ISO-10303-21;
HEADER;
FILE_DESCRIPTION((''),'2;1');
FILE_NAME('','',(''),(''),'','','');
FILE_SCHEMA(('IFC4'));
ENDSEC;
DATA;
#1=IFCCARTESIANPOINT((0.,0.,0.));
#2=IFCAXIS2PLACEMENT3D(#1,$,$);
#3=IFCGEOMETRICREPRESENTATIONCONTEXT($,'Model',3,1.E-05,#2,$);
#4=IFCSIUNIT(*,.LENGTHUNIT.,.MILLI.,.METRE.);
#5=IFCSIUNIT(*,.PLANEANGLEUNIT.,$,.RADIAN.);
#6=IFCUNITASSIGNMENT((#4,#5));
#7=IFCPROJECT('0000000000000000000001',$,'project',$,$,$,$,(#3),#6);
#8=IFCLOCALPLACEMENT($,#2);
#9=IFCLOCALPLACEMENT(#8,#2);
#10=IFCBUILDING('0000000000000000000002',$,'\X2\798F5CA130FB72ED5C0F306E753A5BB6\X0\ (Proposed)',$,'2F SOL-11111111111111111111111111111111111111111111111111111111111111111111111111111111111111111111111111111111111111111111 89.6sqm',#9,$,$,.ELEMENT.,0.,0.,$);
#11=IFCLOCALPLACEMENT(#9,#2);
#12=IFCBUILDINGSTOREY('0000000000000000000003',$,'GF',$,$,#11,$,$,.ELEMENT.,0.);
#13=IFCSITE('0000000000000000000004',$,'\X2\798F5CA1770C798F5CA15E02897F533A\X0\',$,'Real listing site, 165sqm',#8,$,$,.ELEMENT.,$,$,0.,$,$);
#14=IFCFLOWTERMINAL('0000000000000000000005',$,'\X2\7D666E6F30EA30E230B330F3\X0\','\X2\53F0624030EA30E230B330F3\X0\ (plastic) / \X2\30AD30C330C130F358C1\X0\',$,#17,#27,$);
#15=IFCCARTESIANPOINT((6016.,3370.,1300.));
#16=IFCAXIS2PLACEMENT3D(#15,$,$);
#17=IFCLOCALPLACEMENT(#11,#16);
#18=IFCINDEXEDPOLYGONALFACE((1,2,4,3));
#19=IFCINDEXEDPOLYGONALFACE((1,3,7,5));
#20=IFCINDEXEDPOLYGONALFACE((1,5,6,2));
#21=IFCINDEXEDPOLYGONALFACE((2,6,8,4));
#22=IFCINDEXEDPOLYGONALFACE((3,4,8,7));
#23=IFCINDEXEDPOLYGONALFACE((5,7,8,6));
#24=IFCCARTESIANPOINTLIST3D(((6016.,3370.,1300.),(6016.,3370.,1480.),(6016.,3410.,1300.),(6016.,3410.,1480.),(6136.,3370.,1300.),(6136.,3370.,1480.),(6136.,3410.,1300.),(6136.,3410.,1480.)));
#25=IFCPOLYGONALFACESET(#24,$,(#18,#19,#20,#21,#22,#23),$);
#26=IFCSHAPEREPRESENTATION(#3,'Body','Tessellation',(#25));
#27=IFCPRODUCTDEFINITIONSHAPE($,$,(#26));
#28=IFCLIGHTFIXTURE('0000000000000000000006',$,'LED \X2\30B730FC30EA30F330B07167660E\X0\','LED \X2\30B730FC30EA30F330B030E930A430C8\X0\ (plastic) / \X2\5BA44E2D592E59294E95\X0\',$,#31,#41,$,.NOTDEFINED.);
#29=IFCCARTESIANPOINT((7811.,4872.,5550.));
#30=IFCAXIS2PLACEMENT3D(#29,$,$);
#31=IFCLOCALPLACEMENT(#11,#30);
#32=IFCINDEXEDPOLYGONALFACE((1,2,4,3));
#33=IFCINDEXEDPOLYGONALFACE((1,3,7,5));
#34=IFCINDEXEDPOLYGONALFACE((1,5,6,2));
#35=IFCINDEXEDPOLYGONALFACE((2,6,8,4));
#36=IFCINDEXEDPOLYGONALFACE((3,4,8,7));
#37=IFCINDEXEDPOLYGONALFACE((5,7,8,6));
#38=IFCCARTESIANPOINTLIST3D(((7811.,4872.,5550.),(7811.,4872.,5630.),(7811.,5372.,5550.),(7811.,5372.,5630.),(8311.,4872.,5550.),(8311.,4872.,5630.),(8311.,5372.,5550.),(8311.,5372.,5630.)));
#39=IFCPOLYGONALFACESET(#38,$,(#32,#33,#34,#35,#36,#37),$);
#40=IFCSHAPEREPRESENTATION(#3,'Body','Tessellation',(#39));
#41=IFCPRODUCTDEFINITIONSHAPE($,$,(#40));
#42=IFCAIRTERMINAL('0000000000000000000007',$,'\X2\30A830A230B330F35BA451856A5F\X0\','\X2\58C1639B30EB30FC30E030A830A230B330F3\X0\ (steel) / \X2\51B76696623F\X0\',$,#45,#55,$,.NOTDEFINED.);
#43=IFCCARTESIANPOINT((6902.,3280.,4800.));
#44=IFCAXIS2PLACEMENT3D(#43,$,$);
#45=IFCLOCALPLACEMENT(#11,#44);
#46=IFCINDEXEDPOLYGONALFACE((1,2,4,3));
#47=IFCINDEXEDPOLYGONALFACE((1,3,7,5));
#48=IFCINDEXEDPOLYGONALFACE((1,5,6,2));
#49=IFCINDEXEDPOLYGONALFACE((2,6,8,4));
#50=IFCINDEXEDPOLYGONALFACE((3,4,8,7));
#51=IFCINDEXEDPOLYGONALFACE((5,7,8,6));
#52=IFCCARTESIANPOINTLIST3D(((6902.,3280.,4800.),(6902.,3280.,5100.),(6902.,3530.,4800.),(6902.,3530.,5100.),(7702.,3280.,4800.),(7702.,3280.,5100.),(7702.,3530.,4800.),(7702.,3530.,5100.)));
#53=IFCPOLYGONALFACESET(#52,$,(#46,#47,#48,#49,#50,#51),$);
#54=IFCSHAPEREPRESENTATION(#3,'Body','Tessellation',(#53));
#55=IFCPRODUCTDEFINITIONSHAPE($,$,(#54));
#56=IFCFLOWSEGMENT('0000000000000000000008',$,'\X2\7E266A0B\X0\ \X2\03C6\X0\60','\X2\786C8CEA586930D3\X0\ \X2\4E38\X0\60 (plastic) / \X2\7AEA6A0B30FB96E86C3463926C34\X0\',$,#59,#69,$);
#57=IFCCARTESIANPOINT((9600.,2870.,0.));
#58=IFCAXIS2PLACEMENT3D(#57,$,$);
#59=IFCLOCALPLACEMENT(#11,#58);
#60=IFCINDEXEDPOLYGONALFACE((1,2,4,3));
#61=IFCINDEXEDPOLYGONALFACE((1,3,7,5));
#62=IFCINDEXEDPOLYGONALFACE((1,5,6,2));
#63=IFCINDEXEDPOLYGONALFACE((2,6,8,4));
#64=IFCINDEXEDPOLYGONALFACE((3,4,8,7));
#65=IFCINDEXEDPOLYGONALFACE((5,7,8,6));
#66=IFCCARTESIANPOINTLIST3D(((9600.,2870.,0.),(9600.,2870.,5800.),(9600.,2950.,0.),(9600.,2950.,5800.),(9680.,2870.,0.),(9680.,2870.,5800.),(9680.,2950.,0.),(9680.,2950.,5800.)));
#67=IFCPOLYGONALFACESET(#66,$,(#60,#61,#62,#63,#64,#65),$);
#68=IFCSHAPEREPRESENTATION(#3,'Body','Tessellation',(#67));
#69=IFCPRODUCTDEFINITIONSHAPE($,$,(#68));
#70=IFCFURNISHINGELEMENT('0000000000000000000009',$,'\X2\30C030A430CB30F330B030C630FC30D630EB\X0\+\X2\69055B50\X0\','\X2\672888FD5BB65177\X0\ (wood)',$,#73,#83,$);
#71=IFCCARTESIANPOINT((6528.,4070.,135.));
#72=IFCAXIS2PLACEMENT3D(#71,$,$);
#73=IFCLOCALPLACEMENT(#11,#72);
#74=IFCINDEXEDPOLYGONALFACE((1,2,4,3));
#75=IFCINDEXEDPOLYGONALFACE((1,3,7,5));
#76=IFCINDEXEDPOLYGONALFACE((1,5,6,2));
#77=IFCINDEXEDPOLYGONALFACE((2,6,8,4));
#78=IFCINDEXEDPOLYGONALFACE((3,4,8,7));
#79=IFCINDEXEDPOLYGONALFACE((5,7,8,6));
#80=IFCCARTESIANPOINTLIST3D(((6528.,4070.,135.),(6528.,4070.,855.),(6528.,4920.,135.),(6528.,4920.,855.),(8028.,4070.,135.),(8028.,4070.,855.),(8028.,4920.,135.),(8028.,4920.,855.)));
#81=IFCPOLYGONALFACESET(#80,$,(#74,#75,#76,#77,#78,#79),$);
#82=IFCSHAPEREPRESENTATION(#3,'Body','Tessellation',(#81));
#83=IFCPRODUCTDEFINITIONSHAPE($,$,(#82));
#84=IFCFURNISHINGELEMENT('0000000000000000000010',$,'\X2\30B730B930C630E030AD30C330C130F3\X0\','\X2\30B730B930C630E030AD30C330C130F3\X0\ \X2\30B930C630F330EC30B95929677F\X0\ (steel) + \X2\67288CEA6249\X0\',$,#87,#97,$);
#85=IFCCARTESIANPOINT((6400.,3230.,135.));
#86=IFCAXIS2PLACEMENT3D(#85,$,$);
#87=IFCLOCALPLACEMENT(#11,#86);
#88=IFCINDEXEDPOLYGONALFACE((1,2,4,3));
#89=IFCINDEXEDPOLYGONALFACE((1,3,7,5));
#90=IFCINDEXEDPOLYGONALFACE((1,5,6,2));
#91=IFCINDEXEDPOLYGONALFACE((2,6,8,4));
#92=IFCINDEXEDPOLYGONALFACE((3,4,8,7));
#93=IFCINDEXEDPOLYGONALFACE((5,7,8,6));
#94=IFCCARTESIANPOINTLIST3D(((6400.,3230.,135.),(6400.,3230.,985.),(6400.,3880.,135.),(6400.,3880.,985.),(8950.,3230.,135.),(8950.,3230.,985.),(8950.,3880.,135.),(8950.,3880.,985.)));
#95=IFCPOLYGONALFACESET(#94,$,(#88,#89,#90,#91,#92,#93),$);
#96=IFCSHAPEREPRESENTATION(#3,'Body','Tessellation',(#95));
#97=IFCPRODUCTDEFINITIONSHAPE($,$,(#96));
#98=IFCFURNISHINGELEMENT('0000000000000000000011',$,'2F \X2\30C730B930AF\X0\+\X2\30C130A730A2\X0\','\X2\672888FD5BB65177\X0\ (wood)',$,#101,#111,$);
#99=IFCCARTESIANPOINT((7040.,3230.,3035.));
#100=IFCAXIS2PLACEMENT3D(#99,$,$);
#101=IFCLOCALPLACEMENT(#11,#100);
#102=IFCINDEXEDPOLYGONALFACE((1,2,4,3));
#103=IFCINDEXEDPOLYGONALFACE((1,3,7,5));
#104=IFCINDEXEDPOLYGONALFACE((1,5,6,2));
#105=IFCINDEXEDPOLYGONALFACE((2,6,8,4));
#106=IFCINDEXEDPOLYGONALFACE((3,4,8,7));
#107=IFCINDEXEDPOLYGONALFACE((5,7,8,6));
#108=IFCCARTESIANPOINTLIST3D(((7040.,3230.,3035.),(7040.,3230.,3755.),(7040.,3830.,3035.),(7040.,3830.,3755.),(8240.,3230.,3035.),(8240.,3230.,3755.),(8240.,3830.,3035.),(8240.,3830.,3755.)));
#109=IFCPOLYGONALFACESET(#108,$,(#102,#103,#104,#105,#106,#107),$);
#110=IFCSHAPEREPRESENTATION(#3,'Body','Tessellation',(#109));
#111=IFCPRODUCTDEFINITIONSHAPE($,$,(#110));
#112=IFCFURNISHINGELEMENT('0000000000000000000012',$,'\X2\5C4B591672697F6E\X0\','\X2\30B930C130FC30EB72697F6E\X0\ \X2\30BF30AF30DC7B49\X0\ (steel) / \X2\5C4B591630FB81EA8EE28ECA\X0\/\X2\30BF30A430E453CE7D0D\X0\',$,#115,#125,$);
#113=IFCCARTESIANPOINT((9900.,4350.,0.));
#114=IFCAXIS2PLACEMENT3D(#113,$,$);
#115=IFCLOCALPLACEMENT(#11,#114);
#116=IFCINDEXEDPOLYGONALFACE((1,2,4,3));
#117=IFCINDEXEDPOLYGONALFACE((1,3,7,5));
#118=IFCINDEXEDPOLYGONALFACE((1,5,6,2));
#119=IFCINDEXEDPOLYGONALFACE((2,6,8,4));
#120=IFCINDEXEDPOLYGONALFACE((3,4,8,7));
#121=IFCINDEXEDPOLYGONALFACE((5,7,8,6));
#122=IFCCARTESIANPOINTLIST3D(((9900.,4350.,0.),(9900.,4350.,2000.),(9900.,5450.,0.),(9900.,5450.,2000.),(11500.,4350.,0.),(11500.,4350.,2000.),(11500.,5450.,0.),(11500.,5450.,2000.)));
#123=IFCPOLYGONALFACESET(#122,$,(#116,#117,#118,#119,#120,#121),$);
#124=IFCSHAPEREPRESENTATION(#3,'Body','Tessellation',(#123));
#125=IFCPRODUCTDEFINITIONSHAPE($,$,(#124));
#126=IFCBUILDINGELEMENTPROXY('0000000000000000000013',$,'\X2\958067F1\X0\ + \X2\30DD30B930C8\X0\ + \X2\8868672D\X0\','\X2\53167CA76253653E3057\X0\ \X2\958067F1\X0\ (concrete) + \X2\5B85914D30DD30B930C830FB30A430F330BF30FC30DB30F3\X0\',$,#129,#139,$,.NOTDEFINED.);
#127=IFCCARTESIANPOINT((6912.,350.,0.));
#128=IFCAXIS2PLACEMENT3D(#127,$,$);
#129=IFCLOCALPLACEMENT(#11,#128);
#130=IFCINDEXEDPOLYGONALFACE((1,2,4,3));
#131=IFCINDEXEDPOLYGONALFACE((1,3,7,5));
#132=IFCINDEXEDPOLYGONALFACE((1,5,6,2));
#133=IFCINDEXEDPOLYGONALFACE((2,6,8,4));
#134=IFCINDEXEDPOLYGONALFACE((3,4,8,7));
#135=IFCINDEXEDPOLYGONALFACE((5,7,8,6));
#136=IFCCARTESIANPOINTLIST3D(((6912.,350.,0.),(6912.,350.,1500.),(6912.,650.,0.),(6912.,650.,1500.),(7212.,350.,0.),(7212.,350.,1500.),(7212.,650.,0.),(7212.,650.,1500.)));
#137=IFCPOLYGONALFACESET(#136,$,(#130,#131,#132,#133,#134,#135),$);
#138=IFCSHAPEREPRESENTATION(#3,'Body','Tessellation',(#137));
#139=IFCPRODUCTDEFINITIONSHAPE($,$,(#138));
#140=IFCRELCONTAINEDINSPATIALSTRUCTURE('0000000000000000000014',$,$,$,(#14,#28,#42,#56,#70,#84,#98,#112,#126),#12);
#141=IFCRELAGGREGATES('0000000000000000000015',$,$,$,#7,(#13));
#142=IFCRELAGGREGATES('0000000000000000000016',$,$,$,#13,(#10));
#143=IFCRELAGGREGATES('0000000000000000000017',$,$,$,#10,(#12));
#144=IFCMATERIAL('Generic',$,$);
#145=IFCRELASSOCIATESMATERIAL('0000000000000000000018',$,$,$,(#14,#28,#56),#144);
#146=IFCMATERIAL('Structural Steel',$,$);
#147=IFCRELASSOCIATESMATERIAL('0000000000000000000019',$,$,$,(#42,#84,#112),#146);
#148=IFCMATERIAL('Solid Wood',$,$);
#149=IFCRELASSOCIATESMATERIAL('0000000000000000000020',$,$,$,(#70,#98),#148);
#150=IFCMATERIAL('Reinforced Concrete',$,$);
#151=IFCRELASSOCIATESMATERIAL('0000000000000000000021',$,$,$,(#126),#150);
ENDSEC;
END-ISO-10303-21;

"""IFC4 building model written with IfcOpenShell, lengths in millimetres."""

from ifc_helpers import new_model, si_unit, frame, frame_2d, origin, place, context, project, spatial, rectangle, extrude, material, element, save


model = new_model("IFC4")

# Units and contexts
model_context = context("Model", 3, precision=1e-05, world=origin())
ifc_project = project(units=[si_unit("LENGTHUNIT", "METRE", prefix="MILLI"), si_unit("PLANEANGLEUNIT", "RADIAN")], contexts=[model_context])

# Site, building, storey
site_placement = place(None, origin())
site = spatial("IfcSite", under=ifc_project, at=site_placement, Name="福岡県福岡市西区", ObjectType="Real listing site, 165sqm", CompositionType="ELEMENT", RefElevation=0.0)
building_placement = place(site_placement, origin())
building = spatial("IfcBuilding", under=site, at=building_placement, Name="福岡・狭小の町家 (Proposed)", ObjectType="2F SOL-11111111111111111111111111111111111111111111111111111111111111111111111111111111111111111111111111111111111111111111 89.6sqm", CompositionType="ELEMENT", ElevationOfRefHeight=0.0, ElevationOfTerrain=0.0)
storey_placement = place(building_placement, origin())
storey = spatial("IfcBuildingStorey", under=building, at=storey_placement, Name="GF", CompositionType="ELEMENT", Elevation=0.0)

# Shared definitions
ifc_material_1 = material(Name="Solid Wood")

# Shared definitions
ifc_material_2 = material(Name="Reinforced Concrete")

# Shared definitions
ifc_material_3 = material(Name="Structural Steel")

# Flow terminal
ifc_material_4 = material(Name="Generic")
flow_terminal_1_placement = place(storey_placement, frame((6016.0, 3370.0, 1300.0)))
element("IfcFlowTerminal", 1, at=flow_terminal_1_placement, inside=storey, material=ifc_material_4, Name="給湯リモコン", Description="台所リモコン (plastic) / キッチン壁", context=model_context, shape_type="SweptSolid", body=[
    extrude(rectangle(XDim=120.0, YDim=40.0, at=frame_2d((60.0, 20.0))), frame((6016.0, 3370.0, 1300.0)), (0.0, 0.0, 1.0), 180.0),
])

# Light fixture
light_fixture_placement = place(storey_placement, frame((7811.0, 4872.0, 5550.0)))
element("IfcLightFixture", 2, at=light_fixture_placement, inside=storey, material=ifc_material_4, Name="LED シーリング照明", Description="LED シーリングライト (plastic) / 室中央天井", PredefinedType="NOTDEFINED", context=model_context, shape_type="SweptSolid", body=[
    extrude(rectangle(XDim=500.0, YDim=500.0, at=frame_2d((250.0, 250.0))), frame((7811.0, 4872.0, 5550.0)), (0.0, 0.0, 1.0), 80.0),
])

# Air terminal
air_terminal_placement = place(storey_placement, frame((6902.0, 3280.0, 4800.0)))
element("IfcAirTerminal", 3, at=air_terminal_placement, inside=storey, material=ifc_material_3, Name="エアコン室内機", Description="壁掛ルームエアコン (steel) / 冷暖房", PredefinedType="NOTDEFINED", context=model_context, shape_type="SweptSolid", body=[
    extrude(rectangle(XDim=800.0, YDim=250.0, at=frame_2d((400.0, 125.0))), frame((6902.0, 3280.0, 4800.0)), (0.0, 0.0, 1.0), 300.0),
])

# Flow segment
flow_segment_placement = place(storey_placement, frame((9600.0, 2870.0, 0.0)))
element("IfcFlowSegment", 4, at=flow_segment_placement, inside=storey, material=ifc_material_4, Name="縦樋 φ60", Description="硬質塩ビ 丸60 (plastic) / 竪樋・雨水排水", context=model_context, shape_type="SweptSolid", body=[
    extrude(rectangle(XDim=80.0, YDim=80.0, at=frame_2d((40.0, 40.0))), frame((9600.0, 2870.0, 0.0)), (0.0, 0.0, 1.0), 5800.0),
])

# Furnishing elements
furnishing_1_placement = place(storey_placement, frame((6528.0, 4070.0, 135.0)))
element("IfcFurnishingElement", 5, at=furnishing_1_placement, inside=storey, material=ifc_material_1, Name="ダイニングテーブル+椅子", Description="木製家具 (wood)", context=model_context, shape_type="SweptSolid", body=[
    extrude(rectangle(XDim=1500.0, YDim=850.0, at=frame_2d((750.0, 425.0))), frame((6528.0, 4070.0, 135.0)), (0.0, 0.0, 1.0), 720.0),
])
furnishing_2_placement = place(storey_placement, frame((6400.0, 3230.0, 135.0)))
element("IfcFurnishingElement", 6, at=furnishing_2_placement, inside=storey, material=ifc_material_3, Name="システムキッチン", Description="システムキッチン ステンレス天板 (steel) + 木質扉", context=model_context, shape_type="SweptSolid", body=[
    extrude(rectangle(XDim=2550.0, YDim=650.0, at=frame_2d((1275.0, 325.0))), frame((6400.0, 3230.0, 135.0)), (0.0, 0.0, 1.0), 850.0),
])
furnishing_3_placement = place(storey_placement, frame((7040.0, 3230.0, 3035.0)))
element("IfcFurnishingElement", 7, at=furnishing_3_placement, inside=storey, material=ifc_material_1, Name="2F デスク+チェア", Description="木製家具 (wood)", context=model_context, shape_type="SweptSolid", body=[
    extrude(rectangle(XDim=1200.0, YDim=600.0, at=frame_2d((600.0, 300.0))), frame((7040.0, 3230.0, 3035.0)), (0.0, 0.0, 1.0), 720.0),
])
furnishing_4_placement = place(storey_placement, frame((9900.0, 4350.0, 0.0)))
element("IfcFurnishingElement", 8, at=furnishing_4_placement, inside=storey, material=ifc_material_3, Name="屋外物置", Description="スチール物置 タクボ等 (steel) / 屋外・自転車/タイヤ収納", context=model_context, shape_type="SweptSolid", body=[
    extrude(rectangle(XDim=1600.0, YDim=1100.0, at=frame_2d((800.0, 550.0))), frame((9900.0, 4350.0, 0.0)), (0.0, 0.0, 1.0), 2000.0),
])

# Building element proxy
proxy_placement = place(storey_placement, frame((6912.0, 350.0, 0.0)))
element("IfcBuildingElementProxy", 9, at=proxy_placement, inside=storey, material=ifc_material_2, Name="門柱 + ポスト + 表札", Description="化粧打放し 門柱 (concrete) + 宅配ポスト・インターホン", PredefinedType="NOTDEFINED", context=model_context, shape_type="SweptSolid", body=[
    extrude(rectangle(XDim=300.0, YDim=300.0, at=frame_2d((150.0, 150.0))), frame((6912.0, 350.0, 0.0)), (0.0, 0.0, 1.0), 1500.0),
])

save(model, "model.ifc")
